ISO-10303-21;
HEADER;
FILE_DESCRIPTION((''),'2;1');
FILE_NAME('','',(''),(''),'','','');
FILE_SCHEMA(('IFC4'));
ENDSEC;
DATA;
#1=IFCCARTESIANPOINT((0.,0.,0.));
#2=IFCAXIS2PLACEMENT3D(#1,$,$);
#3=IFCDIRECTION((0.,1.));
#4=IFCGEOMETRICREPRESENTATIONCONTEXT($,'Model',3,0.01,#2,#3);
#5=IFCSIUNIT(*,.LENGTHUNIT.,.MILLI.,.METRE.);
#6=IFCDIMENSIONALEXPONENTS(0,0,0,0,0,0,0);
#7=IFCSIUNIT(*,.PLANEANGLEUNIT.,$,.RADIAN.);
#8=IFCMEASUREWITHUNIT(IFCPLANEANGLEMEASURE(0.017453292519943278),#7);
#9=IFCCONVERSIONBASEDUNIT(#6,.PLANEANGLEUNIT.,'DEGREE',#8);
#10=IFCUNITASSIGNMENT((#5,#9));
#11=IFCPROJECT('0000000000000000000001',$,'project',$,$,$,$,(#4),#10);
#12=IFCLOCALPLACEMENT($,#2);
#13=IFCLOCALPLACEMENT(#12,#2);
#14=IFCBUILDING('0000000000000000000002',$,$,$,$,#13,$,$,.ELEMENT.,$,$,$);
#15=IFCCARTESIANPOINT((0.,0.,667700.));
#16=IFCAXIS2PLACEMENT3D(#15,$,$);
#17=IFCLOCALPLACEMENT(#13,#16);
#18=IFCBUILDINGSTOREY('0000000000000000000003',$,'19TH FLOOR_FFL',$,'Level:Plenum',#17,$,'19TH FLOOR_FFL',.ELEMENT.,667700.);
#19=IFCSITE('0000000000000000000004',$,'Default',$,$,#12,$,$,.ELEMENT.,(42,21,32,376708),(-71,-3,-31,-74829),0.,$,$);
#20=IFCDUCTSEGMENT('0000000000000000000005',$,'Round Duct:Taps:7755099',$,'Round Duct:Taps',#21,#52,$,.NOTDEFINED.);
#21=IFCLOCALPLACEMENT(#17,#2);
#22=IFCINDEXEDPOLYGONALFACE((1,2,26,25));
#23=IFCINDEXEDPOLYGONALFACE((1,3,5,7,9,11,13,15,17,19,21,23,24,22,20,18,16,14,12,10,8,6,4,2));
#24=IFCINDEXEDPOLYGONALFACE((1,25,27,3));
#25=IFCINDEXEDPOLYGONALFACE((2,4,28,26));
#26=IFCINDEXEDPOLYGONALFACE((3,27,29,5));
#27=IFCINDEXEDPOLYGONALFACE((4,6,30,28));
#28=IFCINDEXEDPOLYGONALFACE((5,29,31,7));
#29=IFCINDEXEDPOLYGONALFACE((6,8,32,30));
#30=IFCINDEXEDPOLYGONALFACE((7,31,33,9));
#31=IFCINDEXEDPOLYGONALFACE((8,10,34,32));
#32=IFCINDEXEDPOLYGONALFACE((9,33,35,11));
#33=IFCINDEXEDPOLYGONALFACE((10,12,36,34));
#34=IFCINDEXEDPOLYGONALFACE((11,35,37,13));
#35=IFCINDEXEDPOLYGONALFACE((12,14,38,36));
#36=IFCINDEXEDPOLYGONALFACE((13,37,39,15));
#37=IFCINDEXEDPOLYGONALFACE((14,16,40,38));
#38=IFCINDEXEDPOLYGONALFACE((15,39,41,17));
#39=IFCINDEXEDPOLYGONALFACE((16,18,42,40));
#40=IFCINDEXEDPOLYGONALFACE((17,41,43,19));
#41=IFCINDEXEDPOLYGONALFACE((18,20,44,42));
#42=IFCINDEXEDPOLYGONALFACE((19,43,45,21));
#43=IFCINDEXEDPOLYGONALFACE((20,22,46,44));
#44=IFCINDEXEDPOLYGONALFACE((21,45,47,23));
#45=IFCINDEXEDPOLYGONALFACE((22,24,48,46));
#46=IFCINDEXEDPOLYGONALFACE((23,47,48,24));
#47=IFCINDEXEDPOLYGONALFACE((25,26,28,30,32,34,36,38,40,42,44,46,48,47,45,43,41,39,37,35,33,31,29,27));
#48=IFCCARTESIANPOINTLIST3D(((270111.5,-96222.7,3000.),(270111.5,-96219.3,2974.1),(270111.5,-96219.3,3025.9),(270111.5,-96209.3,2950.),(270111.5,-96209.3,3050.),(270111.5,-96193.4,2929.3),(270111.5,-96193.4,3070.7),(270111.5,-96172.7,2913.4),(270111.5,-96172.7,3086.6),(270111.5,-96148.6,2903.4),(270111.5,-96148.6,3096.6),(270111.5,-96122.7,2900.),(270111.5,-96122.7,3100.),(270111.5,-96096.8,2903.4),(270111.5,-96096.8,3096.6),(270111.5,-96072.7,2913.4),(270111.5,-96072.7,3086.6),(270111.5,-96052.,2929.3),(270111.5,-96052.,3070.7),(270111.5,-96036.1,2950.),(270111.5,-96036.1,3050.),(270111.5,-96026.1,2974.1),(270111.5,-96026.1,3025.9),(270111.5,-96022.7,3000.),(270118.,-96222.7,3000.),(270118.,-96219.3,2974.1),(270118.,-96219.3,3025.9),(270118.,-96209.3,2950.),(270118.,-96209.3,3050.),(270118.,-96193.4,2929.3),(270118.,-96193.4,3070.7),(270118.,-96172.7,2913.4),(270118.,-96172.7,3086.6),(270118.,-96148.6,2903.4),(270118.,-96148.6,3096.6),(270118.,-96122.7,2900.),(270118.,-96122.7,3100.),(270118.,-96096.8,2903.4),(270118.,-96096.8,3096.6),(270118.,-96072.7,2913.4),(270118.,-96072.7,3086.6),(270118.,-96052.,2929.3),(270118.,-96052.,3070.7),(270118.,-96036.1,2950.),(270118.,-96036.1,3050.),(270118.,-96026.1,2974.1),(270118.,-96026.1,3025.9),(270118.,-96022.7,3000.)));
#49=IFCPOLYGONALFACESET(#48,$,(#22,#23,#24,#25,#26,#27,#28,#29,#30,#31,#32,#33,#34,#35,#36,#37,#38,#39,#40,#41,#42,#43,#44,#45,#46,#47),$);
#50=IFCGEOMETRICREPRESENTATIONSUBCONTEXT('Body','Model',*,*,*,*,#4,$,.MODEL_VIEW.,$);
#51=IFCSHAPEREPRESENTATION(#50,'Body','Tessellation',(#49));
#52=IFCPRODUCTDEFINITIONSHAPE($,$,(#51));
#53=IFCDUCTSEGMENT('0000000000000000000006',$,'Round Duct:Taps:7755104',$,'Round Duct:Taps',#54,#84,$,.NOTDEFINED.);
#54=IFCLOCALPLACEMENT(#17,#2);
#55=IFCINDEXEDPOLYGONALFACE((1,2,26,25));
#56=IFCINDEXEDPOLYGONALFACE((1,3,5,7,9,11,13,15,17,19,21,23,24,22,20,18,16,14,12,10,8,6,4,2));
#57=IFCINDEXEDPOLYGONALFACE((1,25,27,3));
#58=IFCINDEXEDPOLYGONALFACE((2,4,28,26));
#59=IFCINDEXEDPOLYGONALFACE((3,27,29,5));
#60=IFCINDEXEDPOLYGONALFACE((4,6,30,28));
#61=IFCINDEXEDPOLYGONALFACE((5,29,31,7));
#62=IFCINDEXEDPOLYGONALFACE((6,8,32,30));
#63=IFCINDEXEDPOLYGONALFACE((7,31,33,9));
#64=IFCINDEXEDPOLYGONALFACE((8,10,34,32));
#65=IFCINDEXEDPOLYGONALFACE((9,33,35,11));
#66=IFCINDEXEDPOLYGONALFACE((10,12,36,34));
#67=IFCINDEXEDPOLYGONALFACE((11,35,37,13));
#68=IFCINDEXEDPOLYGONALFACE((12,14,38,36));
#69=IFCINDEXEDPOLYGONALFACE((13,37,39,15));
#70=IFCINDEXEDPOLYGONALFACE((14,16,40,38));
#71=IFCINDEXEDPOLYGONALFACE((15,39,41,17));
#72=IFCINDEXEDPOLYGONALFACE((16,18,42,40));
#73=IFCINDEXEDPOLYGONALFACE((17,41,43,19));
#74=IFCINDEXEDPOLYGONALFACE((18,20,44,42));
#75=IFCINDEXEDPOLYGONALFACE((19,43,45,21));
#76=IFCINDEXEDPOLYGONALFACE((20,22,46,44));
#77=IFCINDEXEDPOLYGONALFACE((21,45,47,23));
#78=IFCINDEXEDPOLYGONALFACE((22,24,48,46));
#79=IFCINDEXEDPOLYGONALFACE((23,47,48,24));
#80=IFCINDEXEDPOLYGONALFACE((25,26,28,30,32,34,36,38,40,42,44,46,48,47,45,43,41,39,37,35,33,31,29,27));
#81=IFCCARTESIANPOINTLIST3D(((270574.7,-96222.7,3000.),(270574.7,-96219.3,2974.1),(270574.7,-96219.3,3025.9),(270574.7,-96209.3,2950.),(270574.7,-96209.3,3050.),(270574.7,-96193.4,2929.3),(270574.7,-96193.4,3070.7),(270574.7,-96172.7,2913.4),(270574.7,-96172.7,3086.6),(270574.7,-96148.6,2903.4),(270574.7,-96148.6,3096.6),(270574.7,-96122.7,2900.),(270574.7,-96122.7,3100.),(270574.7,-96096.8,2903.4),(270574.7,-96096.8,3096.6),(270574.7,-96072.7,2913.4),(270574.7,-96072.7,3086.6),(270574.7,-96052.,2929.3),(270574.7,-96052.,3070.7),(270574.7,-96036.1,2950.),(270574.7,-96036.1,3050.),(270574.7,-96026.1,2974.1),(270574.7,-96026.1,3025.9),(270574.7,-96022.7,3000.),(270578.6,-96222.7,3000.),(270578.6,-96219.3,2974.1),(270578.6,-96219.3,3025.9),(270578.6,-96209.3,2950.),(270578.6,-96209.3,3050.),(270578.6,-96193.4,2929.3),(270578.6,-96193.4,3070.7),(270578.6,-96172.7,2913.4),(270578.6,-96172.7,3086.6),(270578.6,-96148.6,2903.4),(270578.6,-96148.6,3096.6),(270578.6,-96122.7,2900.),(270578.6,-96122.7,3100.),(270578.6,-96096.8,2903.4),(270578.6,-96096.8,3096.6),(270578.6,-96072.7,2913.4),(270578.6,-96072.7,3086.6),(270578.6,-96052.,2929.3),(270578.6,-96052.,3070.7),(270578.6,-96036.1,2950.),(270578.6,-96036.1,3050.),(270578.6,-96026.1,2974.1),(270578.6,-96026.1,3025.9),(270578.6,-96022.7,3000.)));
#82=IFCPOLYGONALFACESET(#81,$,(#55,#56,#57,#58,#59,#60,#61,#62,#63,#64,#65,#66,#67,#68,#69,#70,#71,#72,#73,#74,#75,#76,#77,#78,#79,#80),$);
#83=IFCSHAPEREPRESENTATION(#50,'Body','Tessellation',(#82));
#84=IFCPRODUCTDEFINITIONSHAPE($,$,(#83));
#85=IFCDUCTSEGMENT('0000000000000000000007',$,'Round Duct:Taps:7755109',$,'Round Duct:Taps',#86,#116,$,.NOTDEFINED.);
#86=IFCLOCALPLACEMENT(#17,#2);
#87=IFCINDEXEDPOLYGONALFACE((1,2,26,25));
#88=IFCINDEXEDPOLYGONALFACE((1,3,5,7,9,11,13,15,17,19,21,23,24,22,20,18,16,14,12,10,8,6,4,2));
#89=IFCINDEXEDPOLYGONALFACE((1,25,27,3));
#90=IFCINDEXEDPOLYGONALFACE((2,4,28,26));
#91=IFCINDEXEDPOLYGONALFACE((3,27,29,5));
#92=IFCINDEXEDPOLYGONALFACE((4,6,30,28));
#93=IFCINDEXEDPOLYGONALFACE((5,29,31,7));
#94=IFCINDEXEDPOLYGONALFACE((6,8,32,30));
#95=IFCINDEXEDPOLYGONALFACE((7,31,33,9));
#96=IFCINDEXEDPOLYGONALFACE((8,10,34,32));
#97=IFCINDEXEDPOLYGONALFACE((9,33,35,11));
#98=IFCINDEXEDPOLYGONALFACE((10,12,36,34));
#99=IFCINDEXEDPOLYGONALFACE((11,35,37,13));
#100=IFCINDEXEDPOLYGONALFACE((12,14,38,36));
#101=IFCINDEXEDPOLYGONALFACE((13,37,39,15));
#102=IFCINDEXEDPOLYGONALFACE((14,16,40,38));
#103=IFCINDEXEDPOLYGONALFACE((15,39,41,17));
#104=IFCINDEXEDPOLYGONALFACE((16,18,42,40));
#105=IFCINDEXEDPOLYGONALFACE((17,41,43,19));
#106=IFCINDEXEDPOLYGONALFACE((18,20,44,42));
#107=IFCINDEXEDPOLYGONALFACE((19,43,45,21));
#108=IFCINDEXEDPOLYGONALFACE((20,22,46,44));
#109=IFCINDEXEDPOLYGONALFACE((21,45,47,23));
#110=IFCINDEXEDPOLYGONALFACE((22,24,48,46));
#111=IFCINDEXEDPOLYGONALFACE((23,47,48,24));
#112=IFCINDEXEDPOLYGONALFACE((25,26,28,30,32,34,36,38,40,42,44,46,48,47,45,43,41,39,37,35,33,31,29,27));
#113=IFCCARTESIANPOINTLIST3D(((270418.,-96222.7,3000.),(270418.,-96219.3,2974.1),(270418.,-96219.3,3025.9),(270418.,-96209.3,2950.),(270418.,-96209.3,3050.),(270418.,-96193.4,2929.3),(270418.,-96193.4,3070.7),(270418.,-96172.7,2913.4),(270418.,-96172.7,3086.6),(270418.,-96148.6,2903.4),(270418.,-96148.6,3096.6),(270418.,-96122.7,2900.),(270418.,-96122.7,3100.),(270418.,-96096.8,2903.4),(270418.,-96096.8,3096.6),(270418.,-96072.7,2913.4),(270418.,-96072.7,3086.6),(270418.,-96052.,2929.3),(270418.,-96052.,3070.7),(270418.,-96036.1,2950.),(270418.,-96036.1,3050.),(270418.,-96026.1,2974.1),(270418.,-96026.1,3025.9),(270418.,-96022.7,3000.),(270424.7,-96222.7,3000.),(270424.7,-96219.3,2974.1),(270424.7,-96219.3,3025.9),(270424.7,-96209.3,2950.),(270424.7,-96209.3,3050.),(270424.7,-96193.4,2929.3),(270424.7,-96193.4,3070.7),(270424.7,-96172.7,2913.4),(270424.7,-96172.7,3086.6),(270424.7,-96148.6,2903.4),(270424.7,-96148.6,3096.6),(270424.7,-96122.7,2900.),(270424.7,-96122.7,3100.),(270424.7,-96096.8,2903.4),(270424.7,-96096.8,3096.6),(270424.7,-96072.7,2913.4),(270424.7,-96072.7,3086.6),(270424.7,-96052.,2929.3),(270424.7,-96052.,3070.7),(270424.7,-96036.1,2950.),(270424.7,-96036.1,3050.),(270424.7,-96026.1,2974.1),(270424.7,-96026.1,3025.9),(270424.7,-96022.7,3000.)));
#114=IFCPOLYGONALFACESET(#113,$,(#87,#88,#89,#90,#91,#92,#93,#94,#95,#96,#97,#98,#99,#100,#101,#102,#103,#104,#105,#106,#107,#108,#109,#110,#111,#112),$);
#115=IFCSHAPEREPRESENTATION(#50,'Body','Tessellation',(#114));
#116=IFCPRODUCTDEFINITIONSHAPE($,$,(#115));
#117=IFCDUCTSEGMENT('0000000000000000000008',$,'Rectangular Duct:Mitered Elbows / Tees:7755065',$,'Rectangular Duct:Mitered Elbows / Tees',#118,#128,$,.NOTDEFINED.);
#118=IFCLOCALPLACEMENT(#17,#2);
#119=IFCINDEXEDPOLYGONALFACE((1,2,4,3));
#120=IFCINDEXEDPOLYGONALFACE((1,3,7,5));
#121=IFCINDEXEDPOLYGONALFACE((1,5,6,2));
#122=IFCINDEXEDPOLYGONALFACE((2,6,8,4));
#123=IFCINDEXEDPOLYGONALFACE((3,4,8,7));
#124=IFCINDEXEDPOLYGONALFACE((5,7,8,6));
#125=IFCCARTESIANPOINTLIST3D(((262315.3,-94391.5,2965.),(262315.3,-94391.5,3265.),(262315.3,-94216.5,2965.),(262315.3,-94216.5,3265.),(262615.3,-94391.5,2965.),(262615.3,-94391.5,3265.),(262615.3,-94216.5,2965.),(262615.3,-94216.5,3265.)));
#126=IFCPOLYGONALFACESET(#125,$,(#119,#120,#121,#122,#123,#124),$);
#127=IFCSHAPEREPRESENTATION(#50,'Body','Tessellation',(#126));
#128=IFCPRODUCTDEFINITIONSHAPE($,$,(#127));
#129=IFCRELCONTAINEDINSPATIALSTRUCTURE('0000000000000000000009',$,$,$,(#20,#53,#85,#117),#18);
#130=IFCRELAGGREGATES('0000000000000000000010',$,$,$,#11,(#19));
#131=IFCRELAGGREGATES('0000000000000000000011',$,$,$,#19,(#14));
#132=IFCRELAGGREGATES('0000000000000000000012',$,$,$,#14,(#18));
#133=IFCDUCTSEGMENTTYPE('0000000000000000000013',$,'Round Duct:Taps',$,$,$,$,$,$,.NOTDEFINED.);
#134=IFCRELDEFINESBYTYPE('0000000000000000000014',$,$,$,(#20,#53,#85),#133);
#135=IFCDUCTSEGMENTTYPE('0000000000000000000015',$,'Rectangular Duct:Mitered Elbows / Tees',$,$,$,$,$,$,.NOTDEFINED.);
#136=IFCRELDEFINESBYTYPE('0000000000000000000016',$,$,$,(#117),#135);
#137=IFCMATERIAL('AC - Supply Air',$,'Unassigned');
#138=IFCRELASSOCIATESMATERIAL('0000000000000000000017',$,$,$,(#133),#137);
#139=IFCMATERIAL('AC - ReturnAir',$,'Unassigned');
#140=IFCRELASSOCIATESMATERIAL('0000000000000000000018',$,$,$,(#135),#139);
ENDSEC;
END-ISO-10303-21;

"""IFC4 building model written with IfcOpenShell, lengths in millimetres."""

from ifc_helpers import new_model, entity, si_unit, converted_unit, direction, frame, origin, place, context, subcontext, project, spatial, arc, indexed_curve, outline, extrude, material, type_object, element, save


model = new_model("IFC4")

# Units and contexts
model_context = context("Model", 3, precision=0.01, world=origin(), true_north=direction((0.0, 1.0)))
body_context = subcontext(model_context, "Body", "Model", "MODEL_VIEW")
ifc_project = project(units=[si_unit("LENGTHUNIT", "METRE", prefix="MILLI"), converted_unit("PLANEANGLEUNIT", "DEGREE", entity("IfcPlaneAngleMeasure", 0.017453292519943278), si_unit("PLANEANGLEUNIT", "RADIAN"), dimensions=[0, 0, 0, 0, 0, 0, 0])], contexts=[model_context])

# Site, building, storey
site_placement = place(None, origin())
site = spatial("IfcSite", under=ifc_project, at=site_placement, Name="Default", CompositionType="ELEMENT", RefLatitude=(42, 21, 32, 376708), RefLongitude=(-71, -3, -31, -74829), RefElevation=0.0)
building_placement = place(site_placement, origin())
building = spatial("IfcBuilding", under=site, at=building_placement, CompositionType="ELEMENT")
storey_placement = place(building_placement, frame((0.0, 0.0, 667700.0)))
storey = spatial("IfcBuildingStorey", under=building, at=storey_placement, Name="19TH FLOOR_FFL", ObjectType="Level:Plenum", LongName="19TH FLOOR_FFL", CompositionType="ELEMENT", Elevation=667700.0)

# Duct segments
ifc_material_1 = material(Name="AC - Supply Air", Category="Unassigned")
duct_segment_type_1 = type_object("IfcDuctSegmentType", Name="Round Duct:Taps", PredefinedType="NOTDEFINED", material=ifc_material_1)
duct_segment_1_placement = place(storey_placement, origin())
element("IfcDuctSegment", 1, at=duct_segment_1_placement, inside=storey, type_object=duct_segment_type_1, Name="Round Duct:Taps:7755099", ObjectType="Round Duct:Taps", PredefinedType="NOTDEFINED", context=body_context, shape_type="SweptSolid", body=[
    extrude(outline(indexed_curve([(100.0, 0.0), (70.7, 70.7), (0.0, 100.0), (-70.7, 70.7), (-100.0, 0.0), (-70.7, -70.7), (0.0, -100.0), (70.7, -70.7)], segments=[arc(1, 2, 3), arc(3, 4, 5), arc(5, 6, 7), arc(7, 8, 1)], self_intersect=False)), frame((270111.5, -96122.7, 3000.0), z_axis=(1.0, 0.0, 0.0), x_axis=(0.0, 1.0, 0.0)), (0.0, 0.0, 1.0), 6.5),
])
duct_segment_2_placement = place(storey_placement, origin())
element("IfcDuctSegment", 2, at=duct_segment_2_placement, inside=storey, type_object=duct_segment_type_1, Name="Round Duct:Taps:7755104", ObjectType="Round Duct:Taps", PredefinedType="NOTDEFINED", context=body_context, shape_type="SweptSolid", body=[
    extrude(outline(indexed_curve([(100.0, 0.0), (70.7, 70.7), (0.0, 100.0), (-70.7, 70.7), (-100.0, 0.0), (-70.7, -70.7), (0.0, -100.0), (70.7, -70.7)], segments=[arc(1, 2, 3), arc(3, 4, 5), arc(5, 6, 7), arc(7, 8, 1)], self_intersect=False)), frame((270574.7, -96122.7, 3000.0), z_axis=(1.0, 0.0, 0.0), x_axis=(0.0, -1.0, 0.0)), (0.0, 0.0, 1.0), 3.9),
])
duct_segment_3_placement = place(storey_placement, origin())
element("IfcDuctSegment", 3, at=duct_segment_3_placement, inside=storey, type_object=duct_segment_type_1, Name="Round Duct:Taps:7755109", ObjectType="Round Duct:Taps", PredefinedType="NOTDEFINED", context=body_context, shape_type="SweptSolid", body=[
    extrude(outline(indexed_curve([(100.0, 0.0), (70.7, 70.7), (0.0, 100.0), (-70.7, 70.7), (-100.0, 0.0), (-70.7, -70.7), (0.0, -100.0), (70.7, -70.7)], segments=[arc(1, 2, 3), arc(3, 4, 5), arc(5, 6, 7), arc(7, 8, 1)], self_intersect=False)), frame((270418.0, -96122.7, 3000.0), z_axis=(1.0, 0.0, 0.0), x_axis=(0.0, -1.0, 0.0)), (0.0, 0.0, 1.0), 6.7),
])
ifc_material_2 = material(Name="AC - ReturnAir", Category="Unassigned")
duct_segment_type_2 = type_object("IfcDuctSegmentType", Name="Rectangular Duct:Mitered Elbows / Tees", PredefinedType="NOTDEFINED", material=ifc_material_2)
duct_segment_4_placement = place(storey_placement, origin())
element("IfcDuctSegment", 4, at=duct_segment_4_placement, inside=storey, type_object=duct_segment_type_2, Name="Rectangular Duct:Mitered Elbows / Tees:7755065", ObjectType="Rectangular Duct:Mitered Elbows / Tees", PredefinedType="NOTDEFINED", context=body_context, shape_type="SweptSolid", body=[
    extrude(outline(indexed_curve([(-87.5, -150.0), (87.5, -150.0), (87.5, 150.0), (-87.5, 150.0), (-87.5, -150.0)], self_intersect=False)), frame((262465.3, -94304.0, 2965.0), z_axis=(0.0, 0.0, 1.0), x_axis=(0.0, -1.0, 0.0)), (0.0, 0.0, 1.0), 300.0),
])

save(model, "model.ifc")
